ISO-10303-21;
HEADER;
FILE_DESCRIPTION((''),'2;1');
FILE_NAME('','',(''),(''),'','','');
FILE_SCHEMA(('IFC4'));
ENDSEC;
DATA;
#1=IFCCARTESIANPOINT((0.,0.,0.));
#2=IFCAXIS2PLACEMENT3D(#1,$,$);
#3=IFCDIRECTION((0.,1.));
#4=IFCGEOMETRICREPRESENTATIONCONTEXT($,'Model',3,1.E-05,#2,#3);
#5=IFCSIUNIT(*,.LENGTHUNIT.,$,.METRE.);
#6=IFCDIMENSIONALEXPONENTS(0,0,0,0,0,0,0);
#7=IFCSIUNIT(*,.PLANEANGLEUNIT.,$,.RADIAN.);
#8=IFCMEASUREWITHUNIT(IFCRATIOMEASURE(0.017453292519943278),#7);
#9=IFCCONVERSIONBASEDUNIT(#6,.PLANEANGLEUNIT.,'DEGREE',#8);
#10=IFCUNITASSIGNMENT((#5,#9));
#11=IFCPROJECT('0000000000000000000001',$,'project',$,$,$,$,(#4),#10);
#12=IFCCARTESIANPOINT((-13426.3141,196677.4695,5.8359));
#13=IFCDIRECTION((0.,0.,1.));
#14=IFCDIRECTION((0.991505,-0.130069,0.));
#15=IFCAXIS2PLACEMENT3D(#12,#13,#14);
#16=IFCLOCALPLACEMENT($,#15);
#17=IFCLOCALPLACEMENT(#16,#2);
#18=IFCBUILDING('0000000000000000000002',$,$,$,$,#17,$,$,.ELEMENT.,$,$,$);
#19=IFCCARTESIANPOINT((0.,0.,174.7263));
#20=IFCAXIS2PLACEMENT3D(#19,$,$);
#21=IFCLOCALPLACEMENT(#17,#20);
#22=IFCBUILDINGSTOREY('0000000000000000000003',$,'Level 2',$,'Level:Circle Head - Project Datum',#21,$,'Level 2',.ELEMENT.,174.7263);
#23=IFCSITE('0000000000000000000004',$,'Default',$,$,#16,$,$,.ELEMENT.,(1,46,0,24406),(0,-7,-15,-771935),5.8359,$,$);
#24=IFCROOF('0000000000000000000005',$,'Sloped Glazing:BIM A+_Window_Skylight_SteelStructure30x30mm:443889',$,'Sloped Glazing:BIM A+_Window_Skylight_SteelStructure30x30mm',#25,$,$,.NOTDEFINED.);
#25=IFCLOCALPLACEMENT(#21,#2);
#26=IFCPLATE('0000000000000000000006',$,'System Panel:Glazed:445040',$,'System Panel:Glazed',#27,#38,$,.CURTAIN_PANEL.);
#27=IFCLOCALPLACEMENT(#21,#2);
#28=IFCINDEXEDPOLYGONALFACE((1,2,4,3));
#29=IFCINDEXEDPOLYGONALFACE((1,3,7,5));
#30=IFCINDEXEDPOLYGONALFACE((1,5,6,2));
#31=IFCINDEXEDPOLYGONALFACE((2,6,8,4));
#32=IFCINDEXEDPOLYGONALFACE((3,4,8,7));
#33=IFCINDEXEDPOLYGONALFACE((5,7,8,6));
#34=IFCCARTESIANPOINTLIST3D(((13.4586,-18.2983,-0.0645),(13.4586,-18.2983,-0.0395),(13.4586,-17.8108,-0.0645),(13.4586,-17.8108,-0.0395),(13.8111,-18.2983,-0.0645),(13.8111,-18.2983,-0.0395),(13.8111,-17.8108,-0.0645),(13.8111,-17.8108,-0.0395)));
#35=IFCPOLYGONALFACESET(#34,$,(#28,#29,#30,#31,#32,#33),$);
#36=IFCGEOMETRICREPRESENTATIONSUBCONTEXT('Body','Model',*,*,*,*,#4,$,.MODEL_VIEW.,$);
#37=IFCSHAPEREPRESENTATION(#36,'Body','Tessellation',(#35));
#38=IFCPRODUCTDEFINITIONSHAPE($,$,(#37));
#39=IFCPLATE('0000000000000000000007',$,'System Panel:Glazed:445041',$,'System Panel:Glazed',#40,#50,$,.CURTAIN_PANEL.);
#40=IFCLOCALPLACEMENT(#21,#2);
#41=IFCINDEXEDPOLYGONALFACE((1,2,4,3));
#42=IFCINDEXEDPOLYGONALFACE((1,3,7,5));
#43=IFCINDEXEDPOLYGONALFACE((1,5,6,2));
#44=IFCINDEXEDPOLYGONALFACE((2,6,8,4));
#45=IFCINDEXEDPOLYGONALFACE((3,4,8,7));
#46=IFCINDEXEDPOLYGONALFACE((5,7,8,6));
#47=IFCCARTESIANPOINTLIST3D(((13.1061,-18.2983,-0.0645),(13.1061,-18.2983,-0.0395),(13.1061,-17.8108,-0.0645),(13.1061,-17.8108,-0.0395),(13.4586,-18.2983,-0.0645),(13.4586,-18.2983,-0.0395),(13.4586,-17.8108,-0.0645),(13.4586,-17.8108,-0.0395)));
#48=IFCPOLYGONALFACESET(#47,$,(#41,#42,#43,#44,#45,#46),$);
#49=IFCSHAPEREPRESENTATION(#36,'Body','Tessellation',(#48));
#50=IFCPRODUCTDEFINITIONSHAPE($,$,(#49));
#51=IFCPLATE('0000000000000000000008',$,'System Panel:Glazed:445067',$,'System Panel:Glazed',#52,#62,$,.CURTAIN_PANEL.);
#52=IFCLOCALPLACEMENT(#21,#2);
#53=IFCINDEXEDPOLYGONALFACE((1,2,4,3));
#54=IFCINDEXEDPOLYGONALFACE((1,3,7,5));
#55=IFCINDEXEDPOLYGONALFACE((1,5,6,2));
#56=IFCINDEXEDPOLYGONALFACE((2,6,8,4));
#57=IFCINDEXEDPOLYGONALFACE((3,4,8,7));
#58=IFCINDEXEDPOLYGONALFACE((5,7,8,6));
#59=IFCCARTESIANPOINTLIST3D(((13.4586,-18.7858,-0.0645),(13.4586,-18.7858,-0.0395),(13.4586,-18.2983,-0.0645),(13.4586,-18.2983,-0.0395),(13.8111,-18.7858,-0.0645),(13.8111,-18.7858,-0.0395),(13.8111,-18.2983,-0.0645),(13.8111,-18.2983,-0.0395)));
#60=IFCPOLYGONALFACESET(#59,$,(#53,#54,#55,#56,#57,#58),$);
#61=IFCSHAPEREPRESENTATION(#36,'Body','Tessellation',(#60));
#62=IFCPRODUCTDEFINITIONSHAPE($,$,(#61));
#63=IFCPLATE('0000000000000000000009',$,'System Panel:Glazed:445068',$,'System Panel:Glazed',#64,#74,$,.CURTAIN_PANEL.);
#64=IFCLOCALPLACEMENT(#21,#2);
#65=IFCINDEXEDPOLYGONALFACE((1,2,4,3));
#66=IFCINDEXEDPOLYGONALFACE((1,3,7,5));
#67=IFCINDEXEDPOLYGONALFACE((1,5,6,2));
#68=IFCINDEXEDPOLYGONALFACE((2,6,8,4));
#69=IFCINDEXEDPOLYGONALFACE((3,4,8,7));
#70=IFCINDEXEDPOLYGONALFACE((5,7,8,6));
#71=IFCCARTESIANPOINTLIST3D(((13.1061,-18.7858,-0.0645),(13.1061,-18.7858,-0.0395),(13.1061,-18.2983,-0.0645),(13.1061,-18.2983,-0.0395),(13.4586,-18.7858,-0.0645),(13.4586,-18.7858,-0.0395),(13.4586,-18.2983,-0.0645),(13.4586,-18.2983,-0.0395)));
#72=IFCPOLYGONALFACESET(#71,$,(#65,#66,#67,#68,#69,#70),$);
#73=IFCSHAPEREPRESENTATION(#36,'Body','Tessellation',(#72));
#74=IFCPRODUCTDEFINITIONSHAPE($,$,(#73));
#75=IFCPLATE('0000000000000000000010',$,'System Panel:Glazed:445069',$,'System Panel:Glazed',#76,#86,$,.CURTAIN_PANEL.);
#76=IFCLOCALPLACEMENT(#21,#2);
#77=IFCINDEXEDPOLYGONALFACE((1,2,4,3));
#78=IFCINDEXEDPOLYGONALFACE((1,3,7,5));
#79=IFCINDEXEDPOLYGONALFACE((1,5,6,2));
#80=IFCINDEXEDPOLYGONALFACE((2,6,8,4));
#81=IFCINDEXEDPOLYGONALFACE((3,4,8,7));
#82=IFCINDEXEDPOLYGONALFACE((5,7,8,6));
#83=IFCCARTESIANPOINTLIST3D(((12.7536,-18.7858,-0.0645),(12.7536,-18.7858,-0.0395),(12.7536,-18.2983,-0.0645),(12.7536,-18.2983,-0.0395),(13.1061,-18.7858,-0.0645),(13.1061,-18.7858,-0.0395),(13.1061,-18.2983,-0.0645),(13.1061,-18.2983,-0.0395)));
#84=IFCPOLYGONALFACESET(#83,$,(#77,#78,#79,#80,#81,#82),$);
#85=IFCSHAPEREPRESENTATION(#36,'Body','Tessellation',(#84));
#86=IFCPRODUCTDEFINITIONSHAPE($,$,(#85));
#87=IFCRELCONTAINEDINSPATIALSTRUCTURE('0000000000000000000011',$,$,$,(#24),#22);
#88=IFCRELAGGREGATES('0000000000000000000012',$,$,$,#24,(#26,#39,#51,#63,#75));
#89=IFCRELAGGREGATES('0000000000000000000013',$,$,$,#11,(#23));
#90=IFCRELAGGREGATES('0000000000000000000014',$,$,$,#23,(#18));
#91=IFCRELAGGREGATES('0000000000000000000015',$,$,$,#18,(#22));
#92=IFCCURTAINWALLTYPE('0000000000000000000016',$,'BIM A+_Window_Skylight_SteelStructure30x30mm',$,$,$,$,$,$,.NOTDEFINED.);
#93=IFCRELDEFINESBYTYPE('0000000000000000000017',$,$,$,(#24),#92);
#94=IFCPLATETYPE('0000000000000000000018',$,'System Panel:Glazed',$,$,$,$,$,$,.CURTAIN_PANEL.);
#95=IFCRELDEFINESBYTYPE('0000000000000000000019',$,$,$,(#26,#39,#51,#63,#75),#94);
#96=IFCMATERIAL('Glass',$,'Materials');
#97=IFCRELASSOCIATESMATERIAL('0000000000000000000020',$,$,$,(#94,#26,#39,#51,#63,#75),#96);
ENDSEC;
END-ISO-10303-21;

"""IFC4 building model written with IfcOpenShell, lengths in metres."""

from ifc_helpers import new_model, entity, si_unit, converted_unit, direction, frame, origin, place, context, subcontext, project, spatial, indexed_curve, outline, extrude, source, transform, mapped, material, type_object, type_shapes, element, aggregate, save


model = new_model("IFC4")

# Units and contexts
model_context = context("Model", 3, precision=1e-05, world=origin(), true_north=direction((0.0, 1.0)))
body_context = subcontext(model_context, "Body", "Model", "MODEL_VIEW")
ifc_project = project(units=[si_unit("LENGTHUNIT", "METRE"), converted_unit("PLANEANGLEUNIT", "DEGREE", entity("IfcRatioMeasure", 0.017453292519943278), si_unit("PLANEANGLEUNIT", "RADIAN"), dimensions=[0, 0, 0, 0, 0, 0, 0])], contexts=[model_context])

# Site, building, storey
site_placement = place(None, frame((-13426.3141, 196677.4695, 5.8359), z_axis=(0.0, 0.0, 1.0), x_axis=(0.991505, -0.130069, 0.0)))
site = spatial("IfcSite", under=ifc_project, at=site_placement, Name="Default", CompositionType="ELEMENT", RefLatitude=(1, 46, 0, 24406), RefLongitude=(0, -7, -15, -771935), RefElevation=5.8359)
building_placement = place(site_placement, origin())
building = spatial("IfcBuilding", under=site, at=building_placement, CompositionType="ELEMENT")
storey_placement = place(building_placement, frame((0.0, 0.0, 174.7263)))
storey = spatial("IfcBuildingStorey", under=building, at=storey_placement, Name="Level 2", ObjectType="Level:Circle Head - Project Datum", LongName="Level 2", CompositionType="ELEMENT", Elevation=174.7263)

# Roof
curtain_wall_type_1 = type_object("IfcCurtainWallType", Name="BIM A+_Window_Skylight_SteelStructure30x30mm", PredefinedType="NOTDEFINED")
roof_1_placement = place(storey_placement, frame((0.0, 0.0, -174.7263)))
roof_1 = element("IfcRoof", 1, at=roof_1_placement, inside=storey, type_object=curtain_wall_type_1, Name="Sloped Glazing:BIM A+_Window_Skylight_SteelStructure30x30mm:443889", ObjectType="Sloped Glazing:BIM A+_Window_Skylight_SteelStructure30x30mm", PredefinedType="NOTDEFINED")

# Plates
ifc_material_1 = material(Name="Glass", Category="Materials")
plate_type_1 = type_object("IfcPlateType", Name="System Panel:Glazed", PredefinedType="CURTAIN_PANEL", material=ifc_material_1)
shared_shape_1 = source(origin(), body_context, "Body", "SweptSolid", [
    extrude(outline(indexed_curve([(-0.0125, -0.1762), (0.0125, -0.1762), (0.0125, 0.1762), (-0.0125, 0.1762), (-0.0125, -0.1762)], self_intersect=False)), frame((0.0, 0.037, 0.0), z_axis=(0.0, 0.0, 1.0), x_axis=(0.0, 1.0, 0.0)), (0.0, 0.0, 1.0), 0.4875),
])
type_shapes(plate_type_1, [shared_shape_1])
plate_1_placement = place(roof_1_placement, frame((13.6348, -17.8108, 174.7113), z_axis=(0.0, -1.0, 0.0), x_axis=(-1.0, 0.0, 0.0)))
plate_1 = element("IfcPlate", 2, at=plate_1_placement, type_object=plate_type_1, material=ifc_material_1, Name="System Panel:Glazed:445040", ObjectType="System Panel:Glazed", PredefinedType="CURTAIN_PANEL", context=body_context, shape_type="MappedRepresentation", body=[
    mapped(shared_shape_1, transform((0.0, 0.0, 0.0), scale=1.0)),
])
plate_2_placement = place(roof_1_placement, frame((13.2823, -17.8108, 174.7113), z_axis=(0.0, -1.0, 0.0), x_axis=(-1.0, 0.0, 0.0)))
plate_2 = element("IfcPlate", 3, at=plate_2_placement, type_object=plate_type_1, material=ifc_material_1, Name="System Panel:Glazed:445041", ObjectType="System Panel:Glazed", PredefinedType="CURTAIN_PANEL", context=body_context, shape_type="MappedRepresentation", body=[
    mapped(shared_shape_1, transform((0.0, 0.0, 0.0), scale=1.0)),
])
plate_3_placement = place(roof_1_placement, frame((13.6348, -18.2983, 174.7113), z_axis=(0.0, -1.0, 0.0), x_axis=(-1.0, 0.0, 0.0)))
plate_3 = element("IfcPlate", 4, at=plate_3_placement, type_object=plate_type_1, material=ifc_material_1, Name="System Panel:Glazed:445067", ObjectType="System Panel:Glazed", PredefinedType="CURTAIN_PANEL", context=body_context, shape_type="MappedRepresentation", body=[
    mapped(shared_shape_1, transform((0.0, 0.0, 0.0), scale=1.0)),
])
plate_4_placement = place(roof_1_placement, frame((13.2823, -18.2983, 174.7113), z_axis=(0.0, -1.0, 0.0), x_axis=(-1.0, 0.0, 0.0)))
plate_4 = element("IfcPlate", 5, at=plate_4_placement, type_object=plate_type_1, material=ifc_material_1, Name="System Panel:Glazed:445068", ObjectType="System Panel:Glazed", PredefinedType="CURTAIN_PANEL", context=body_context, shape_type="MappedRepresentation", body=[
    mapped(shared_shape_1, transform((0.0, 0.0, 0.0), scale=1.0)),
])
plate_5_placement = place(roof_1_placement, frame((12.9298, -18.2983, 174.7113), z_axis=(0.0, -1.0, 0.0), x_axis=(-1.0, 0.0, 0.0)))
plate_5 = element("IfcPlate", 6, at=plate_5_placement, type_object=plate_type_1, material=ifc_material_1, Name="System Panel:Glazed:445069", ObjectType="System Panel:Glazed", PredefinedType="CURTAIN_PANEL", context=body_context, shape_type="MappedRepresentation", body=[
    mapped(shared_shape_1, transform((0.0, 0.0, 0.0), scale=1.0)),
])
aggregate(roof_1, [plate_1, plate_2, plate_3, plate_4, plate_5])

save(model, "model.ifc")
